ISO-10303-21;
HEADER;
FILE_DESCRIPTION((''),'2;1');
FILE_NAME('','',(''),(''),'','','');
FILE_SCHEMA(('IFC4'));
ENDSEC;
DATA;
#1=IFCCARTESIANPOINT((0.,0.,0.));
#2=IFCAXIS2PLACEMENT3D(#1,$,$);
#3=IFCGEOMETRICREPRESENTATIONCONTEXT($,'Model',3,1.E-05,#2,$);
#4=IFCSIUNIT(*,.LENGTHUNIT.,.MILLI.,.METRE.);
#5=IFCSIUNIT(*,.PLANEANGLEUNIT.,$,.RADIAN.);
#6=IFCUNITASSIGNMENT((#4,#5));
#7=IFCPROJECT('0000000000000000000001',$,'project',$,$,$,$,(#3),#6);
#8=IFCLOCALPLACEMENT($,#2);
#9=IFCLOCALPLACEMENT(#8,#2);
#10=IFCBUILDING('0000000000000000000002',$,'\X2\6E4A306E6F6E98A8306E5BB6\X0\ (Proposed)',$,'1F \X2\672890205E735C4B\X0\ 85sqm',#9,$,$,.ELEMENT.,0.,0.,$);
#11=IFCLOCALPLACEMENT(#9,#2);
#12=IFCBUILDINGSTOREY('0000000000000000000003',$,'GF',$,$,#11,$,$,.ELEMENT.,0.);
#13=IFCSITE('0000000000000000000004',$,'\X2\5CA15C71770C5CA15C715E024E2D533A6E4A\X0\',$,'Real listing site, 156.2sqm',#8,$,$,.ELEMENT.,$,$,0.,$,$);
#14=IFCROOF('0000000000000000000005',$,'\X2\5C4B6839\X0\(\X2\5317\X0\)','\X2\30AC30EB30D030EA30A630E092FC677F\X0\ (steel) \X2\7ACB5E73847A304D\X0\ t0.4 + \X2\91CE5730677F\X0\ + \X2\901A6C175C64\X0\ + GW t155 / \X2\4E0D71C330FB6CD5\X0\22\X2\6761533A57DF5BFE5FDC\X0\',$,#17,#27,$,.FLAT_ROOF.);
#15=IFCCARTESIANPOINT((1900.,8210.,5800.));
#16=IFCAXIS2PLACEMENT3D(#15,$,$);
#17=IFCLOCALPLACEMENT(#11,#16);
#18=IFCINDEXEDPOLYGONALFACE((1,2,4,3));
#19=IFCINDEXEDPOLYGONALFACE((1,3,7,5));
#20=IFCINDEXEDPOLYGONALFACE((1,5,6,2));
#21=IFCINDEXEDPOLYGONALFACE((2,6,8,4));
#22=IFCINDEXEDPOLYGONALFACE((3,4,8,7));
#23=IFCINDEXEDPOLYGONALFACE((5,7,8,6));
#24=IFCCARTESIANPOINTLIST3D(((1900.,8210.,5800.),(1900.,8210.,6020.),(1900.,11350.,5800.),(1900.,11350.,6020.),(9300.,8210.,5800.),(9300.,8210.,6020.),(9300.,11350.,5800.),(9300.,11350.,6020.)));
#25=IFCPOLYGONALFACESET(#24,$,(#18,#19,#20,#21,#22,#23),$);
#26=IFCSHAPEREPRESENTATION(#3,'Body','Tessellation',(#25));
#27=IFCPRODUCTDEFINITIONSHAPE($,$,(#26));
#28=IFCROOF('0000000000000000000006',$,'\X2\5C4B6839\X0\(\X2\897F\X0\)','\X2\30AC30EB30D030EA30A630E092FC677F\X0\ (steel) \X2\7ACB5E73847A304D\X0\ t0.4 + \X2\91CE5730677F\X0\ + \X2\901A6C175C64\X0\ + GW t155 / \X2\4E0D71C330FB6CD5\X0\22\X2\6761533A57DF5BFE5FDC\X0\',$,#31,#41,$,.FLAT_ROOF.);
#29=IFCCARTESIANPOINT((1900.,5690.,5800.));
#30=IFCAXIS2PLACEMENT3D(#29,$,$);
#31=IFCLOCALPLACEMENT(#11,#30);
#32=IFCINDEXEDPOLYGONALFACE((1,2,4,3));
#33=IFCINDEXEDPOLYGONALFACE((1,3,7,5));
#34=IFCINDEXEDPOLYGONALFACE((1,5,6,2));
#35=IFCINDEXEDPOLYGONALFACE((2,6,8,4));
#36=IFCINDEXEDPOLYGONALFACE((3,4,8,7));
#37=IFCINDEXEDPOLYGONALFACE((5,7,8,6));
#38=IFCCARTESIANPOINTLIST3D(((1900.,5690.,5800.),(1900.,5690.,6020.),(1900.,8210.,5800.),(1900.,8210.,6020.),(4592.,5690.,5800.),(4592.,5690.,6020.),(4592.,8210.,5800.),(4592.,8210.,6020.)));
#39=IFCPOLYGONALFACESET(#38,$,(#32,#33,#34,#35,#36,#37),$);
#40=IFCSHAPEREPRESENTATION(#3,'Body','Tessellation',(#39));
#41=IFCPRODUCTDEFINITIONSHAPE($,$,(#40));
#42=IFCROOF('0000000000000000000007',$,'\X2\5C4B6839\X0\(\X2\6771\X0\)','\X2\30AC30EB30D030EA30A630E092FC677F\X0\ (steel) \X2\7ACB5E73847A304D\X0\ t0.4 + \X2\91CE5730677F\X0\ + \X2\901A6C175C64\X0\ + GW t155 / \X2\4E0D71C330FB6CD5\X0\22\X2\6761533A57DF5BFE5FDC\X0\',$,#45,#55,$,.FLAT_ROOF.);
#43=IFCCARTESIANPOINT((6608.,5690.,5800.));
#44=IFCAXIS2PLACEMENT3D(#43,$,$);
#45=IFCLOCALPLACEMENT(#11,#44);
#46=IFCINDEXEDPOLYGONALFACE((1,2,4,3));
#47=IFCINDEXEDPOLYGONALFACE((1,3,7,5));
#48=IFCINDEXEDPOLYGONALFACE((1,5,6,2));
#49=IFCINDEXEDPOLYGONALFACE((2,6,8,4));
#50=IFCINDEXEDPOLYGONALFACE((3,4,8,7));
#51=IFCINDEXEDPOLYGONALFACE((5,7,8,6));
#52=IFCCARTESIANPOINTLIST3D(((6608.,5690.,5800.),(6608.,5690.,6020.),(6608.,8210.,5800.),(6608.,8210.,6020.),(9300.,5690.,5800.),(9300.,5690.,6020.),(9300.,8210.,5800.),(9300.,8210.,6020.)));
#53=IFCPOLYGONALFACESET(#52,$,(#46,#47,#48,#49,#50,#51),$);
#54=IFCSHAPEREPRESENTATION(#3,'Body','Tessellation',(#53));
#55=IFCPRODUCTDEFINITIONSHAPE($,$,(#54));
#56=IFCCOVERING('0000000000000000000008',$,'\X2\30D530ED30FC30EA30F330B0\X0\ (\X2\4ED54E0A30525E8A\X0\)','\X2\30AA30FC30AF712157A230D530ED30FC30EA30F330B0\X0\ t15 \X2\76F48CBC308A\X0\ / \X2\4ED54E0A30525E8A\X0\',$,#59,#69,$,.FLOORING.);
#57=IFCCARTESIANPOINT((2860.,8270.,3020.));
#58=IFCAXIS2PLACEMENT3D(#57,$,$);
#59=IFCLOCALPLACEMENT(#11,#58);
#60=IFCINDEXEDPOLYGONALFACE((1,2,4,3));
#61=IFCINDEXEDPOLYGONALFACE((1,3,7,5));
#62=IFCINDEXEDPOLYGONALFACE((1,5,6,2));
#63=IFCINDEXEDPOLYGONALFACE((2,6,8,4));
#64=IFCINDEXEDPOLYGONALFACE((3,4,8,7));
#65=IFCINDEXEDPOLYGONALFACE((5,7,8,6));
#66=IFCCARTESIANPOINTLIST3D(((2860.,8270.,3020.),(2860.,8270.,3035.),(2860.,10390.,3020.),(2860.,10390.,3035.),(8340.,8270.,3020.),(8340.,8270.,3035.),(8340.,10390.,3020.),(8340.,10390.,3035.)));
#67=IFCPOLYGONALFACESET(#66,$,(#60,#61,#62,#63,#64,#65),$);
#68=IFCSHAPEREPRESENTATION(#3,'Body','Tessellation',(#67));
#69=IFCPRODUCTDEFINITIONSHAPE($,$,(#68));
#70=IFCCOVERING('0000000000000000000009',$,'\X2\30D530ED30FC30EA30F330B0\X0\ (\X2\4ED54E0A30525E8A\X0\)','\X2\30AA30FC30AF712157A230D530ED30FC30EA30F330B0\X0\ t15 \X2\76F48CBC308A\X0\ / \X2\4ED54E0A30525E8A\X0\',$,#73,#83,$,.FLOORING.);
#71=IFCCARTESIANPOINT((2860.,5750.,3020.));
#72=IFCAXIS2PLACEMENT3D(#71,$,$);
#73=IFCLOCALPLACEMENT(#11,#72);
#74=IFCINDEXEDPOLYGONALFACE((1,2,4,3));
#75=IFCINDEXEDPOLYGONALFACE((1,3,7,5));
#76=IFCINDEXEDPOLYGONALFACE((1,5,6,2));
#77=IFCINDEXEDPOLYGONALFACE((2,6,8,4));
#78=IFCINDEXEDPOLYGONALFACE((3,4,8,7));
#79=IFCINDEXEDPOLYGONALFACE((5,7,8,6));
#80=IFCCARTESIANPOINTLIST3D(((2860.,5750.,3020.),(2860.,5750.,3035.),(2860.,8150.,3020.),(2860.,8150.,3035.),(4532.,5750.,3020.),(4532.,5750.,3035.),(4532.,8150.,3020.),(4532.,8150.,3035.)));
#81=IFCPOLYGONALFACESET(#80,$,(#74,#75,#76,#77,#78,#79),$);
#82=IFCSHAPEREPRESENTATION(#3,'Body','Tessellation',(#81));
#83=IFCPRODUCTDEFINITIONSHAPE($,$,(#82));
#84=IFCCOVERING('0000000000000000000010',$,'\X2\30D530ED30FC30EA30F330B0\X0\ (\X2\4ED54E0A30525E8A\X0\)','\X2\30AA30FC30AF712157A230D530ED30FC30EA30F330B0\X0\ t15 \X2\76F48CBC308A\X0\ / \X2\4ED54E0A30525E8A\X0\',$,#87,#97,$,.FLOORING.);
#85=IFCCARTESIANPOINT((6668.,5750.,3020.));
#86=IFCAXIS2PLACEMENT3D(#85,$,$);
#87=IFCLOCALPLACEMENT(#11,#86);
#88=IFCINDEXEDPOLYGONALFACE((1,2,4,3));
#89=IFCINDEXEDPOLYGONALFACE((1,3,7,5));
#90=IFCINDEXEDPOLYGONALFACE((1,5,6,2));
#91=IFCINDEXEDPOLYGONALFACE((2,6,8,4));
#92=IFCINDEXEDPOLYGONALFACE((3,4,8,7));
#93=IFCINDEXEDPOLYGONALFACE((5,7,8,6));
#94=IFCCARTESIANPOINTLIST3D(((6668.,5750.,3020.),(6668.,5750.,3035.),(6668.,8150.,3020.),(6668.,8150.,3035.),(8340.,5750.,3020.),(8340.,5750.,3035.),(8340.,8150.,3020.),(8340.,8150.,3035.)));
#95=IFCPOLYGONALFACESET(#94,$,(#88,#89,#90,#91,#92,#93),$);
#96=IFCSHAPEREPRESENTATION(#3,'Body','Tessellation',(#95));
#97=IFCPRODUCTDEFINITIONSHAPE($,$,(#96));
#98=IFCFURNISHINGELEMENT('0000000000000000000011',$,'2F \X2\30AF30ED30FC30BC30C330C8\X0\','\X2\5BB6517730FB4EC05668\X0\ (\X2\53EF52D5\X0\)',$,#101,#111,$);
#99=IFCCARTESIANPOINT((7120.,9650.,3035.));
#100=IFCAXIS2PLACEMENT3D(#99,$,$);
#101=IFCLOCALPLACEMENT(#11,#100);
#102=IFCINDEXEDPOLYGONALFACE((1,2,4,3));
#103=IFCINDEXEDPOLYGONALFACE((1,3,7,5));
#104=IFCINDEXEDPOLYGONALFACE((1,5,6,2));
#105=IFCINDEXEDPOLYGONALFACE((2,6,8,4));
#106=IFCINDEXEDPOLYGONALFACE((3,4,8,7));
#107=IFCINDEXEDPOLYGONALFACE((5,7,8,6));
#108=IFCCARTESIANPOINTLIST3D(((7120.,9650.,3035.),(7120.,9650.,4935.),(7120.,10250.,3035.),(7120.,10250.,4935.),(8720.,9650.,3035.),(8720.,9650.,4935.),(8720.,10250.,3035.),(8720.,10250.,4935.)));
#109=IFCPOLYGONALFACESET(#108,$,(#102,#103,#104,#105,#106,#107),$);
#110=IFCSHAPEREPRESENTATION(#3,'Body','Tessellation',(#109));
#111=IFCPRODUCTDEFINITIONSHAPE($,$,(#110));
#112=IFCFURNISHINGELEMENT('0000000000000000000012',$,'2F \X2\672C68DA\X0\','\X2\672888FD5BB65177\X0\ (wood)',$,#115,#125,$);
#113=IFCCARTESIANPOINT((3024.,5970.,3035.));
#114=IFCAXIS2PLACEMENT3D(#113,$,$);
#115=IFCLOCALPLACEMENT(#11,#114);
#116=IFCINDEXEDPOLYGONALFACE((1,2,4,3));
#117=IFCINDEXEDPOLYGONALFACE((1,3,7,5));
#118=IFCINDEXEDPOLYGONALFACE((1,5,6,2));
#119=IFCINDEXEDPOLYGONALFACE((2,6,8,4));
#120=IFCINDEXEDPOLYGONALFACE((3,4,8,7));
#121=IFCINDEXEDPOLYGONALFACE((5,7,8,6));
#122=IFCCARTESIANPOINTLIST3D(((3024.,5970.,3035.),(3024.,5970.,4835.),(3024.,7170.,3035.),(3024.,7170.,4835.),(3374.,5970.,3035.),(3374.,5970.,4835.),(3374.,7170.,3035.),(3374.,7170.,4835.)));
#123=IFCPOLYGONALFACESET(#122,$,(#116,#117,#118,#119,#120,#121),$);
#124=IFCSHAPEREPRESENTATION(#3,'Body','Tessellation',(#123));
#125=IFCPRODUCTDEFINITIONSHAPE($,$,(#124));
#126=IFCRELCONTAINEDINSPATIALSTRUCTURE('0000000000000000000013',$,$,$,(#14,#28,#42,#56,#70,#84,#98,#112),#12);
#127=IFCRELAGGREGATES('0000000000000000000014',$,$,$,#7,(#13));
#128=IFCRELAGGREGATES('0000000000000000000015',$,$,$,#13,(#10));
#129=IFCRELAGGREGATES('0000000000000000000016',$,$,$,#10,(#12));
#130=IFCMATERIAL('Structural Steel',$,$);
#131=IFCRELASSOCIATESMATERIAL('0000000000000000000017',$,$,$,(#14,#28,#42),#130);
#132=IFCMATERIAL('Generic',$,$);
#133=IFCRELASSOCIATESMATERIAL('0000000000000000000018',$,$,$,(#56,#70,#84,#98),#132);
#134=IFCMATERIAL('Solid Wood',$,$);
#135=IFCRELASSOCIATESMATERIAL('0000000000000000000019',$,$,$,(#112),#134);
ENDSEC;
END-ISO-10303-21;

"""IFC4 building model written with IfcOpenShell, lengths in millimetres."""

from ifc_helpers import new_model, si_unit, frame, frame_2d, origin, place, context, project, spatial, rectangle, extrude, material, element, save


model = new_model("IFC4")

# Units and contexts
model_context = context("Model", 3, precision=1e-05, world=origin())
ifc_project = project(units=[si_unit("LENGTHUNIT", "METRE", prefix="MILLI"), si_unit("PLANEANGLEUNIT", "RADIAN")], contexts=[model_context])

# Site, building, storey
site_placement = place(None, origin())
site = spatial("IfcSite", under=ifc_project, at=site_placement, Name="岡山県岡山市中区湊", ObjectType="Real listing site, 156.2sqm", CompositionType="ELEMENT", RefElevation=0.0)
building_placement = place(site_placement, origin())
building = spatial("IfcBuilding", under=site, at=building_placement, Name="湊の潮風の家 (Proposed)", ObjectType="1F 木造平屋 85sqm", CompositionType="ELEMENT", ElevationOfRefHeight=0.0, ElevationOfTerrain=0.0)
storey_placement = place(building_placement, origin())
storey = spatial("IfcBuildingStorey", under=building, at=storey_placement, Name="GF", CompositionType="ELEMENT", Elevation=0.0)

# Shared definitions
ifc_material_1 = material(Name="Solid Wood")

# Shared definitions
ifc_material_2 = material(Name="Generic")

# Roofs
ifc_material_3 = material(Name="Structural Steel")
for number, where, name in (
    (1, (1900.0, 8210.0, 5800.0), "屋根(北)"),
):
    element("IfcRoof", number, at=place(storey_placement, frame(where)), inside=storey, material=ifc_material_3, Name=name, Description="ガルバリウム鋼板 (steel) 立平葺き t0.4 + 野地板 + 通気層 + GW t155 / 不燃・法22条区域対応", PredefinedType="FLAT_ROOF", context=model_context, shape_type="SweptSolid", body=[
        extrude(rectangle(XDim=7400.0, YDim=3140.0, at=frame_2d((3700.0, 1570.0))), frame((1900.0, 8210.0, 5800.0)), (0.0, 0.0, 1.0), 220.0),
    ])
roof_1_placement = place(storey_placement, frame((1900.0, 5690.0, 5800.0)))
element("IfcRoof", 2, at=roof_1_placement, inside=storey, material=ifc_material_3, Name="屋根(西)", Description="ガルバリウム鋼板 (steel) 立平葺き t0.4 + 野地板 + 通気層 + GW t155 / 不燃・法22条区域対応", PredefinedType="FLAT_ROOF", context=model_context, shape_type="SweptSolid", body=[
    extrude(rectangle(XDim=2692.0, YDim=2520.0, at=frame_2d((1346.0, 1260.0))), frame((1900.0, 5690.0, 5800.0)), (0.0, 0.0, 1.0), 220.0),
])
roof_2_placement = place(storey_placement, frame((6608.0, 5690.0, 5800.0)))
element("IfcRoof", 3, at=roof_2_placement, inside=storey, material=ifc_material_3, Name="屋根(東)", Description="ガルバリウム鋼板 (steel) 立平葺き t0.4 + 野地板 + 通気層 + GW t155 / 不燃・法22条区域対応", PredefinedType="FLAT_ROOF", context=model_context, shape_type="SweptSolid", body=[
    extrude(rectangle(XDim=2692.0, YDim=2520.0, at=frame_2d((1346.0, 1260.0))), frame((6608.0, 5690.0, 5800.0)), (0.0, 0.0, 1.0), 220.0),
])

# Coverings
covering_1_placement = place(storey_placement, frame((2860.0, 8270.0, 3020.0)))
element("IfcCovering", 4, at=covering_1_placement, inside=storey, material=ifc_material_2, Name="フローリング (仕上げ床)", Description="オーク無垢フローリング t15 直貼り / 仕上げ床", PredefinedType="FLOORING", context=model_context, shape_type="SweptSolid", body=[
    extrude(rectangle(XDim=5480.0, YDim=2120.0, at=frame_2d((2740.0, 1060.0))), frame((2860.0, 8270.0, 3020.0)), (0.0, 0.0, 1.0), 15.0),
])
covering_2_placement = place(storey_placement, frame((2860.0, 5750.0, 3020.0)))
element("IfcCovering", 5, at=covering_2_placement, inside=storey, material=ifc_material_2, Name="フローリング (仕上げ床)", Description="オーク無垢フローリング t15 直貼り / 仕上げ床", PredefinedType="FLOORING", context=model_context, shape_type="SweptSolid", body=[
    extrude(rectangle(XDim=1672.0, YDim=2400.0, at=frame_2d((836.0, 1200.0))), frame((2860.0, 5750.0, 3020.0)), (0.0, 0.0, 1.0), 15.0),
])
covering_3_placement = place(storey_placement, frame((6668.0, 5750.0, 3020.0)))
element("IfcCovering", 6, at=covering_3_placement, inside=storey, material=ifc_material_2, Name="フローリング (仕上げ床)", Description="オーク無垢フローリング t15 直貼り / 仕上げ床", PredefinedType="FLOORING", context=model_context, shape_type="SweptSolid", body=[
    extrude(rectangle(XDim=1672.0, YDim=2400.0, at=frame_2d((836.0, 1200.0))), frame((6668.0, 5750.0, 3020.0)), (0.0, 0.0, 1.0), 15.0),
])

# Furnishing elements
furnishing_1_placement = place(storey_placement, frame((7120.0, 9650.0, 3035.0)))
element("IfcFurnishingElement", 7, at=furnishing_1_placement, inside=storey, material=ifc_material_2, Name="2F クローゼット", Description="家具・什器 (可動)", context=model_context, shape_type="SweptSolid", body=[
    extrude(rectangle(XDim=1600.0, YDim=600.0, at=frame_2d((800.0, 300.0))), frame((7120.0, 9650.0, 3035.0)), (0.0, 0.0, 1.0), 1900.0),
])
furnishing_2_placement = place(storey_placement, frame((3024.0, 5970.0, 3035.0)))
element("IfcFurnishingElement", 8, at=furnishing_2_placement, inside=storey, material=ifc_material_1, Name="2F 本棚", Description="木製家具 (wood)", context=model_context, shape_type="SweptSolid", body=[
    extrude(rectangle(XDim=350.0, YDim=1200.0, at=frame_2d((175.0, 600.0))), frame((3024.0, 5970.0, 3035.0)), (0.0, 0.0, 1.0), 1800.0),
])

save(model, "model.ifc")
